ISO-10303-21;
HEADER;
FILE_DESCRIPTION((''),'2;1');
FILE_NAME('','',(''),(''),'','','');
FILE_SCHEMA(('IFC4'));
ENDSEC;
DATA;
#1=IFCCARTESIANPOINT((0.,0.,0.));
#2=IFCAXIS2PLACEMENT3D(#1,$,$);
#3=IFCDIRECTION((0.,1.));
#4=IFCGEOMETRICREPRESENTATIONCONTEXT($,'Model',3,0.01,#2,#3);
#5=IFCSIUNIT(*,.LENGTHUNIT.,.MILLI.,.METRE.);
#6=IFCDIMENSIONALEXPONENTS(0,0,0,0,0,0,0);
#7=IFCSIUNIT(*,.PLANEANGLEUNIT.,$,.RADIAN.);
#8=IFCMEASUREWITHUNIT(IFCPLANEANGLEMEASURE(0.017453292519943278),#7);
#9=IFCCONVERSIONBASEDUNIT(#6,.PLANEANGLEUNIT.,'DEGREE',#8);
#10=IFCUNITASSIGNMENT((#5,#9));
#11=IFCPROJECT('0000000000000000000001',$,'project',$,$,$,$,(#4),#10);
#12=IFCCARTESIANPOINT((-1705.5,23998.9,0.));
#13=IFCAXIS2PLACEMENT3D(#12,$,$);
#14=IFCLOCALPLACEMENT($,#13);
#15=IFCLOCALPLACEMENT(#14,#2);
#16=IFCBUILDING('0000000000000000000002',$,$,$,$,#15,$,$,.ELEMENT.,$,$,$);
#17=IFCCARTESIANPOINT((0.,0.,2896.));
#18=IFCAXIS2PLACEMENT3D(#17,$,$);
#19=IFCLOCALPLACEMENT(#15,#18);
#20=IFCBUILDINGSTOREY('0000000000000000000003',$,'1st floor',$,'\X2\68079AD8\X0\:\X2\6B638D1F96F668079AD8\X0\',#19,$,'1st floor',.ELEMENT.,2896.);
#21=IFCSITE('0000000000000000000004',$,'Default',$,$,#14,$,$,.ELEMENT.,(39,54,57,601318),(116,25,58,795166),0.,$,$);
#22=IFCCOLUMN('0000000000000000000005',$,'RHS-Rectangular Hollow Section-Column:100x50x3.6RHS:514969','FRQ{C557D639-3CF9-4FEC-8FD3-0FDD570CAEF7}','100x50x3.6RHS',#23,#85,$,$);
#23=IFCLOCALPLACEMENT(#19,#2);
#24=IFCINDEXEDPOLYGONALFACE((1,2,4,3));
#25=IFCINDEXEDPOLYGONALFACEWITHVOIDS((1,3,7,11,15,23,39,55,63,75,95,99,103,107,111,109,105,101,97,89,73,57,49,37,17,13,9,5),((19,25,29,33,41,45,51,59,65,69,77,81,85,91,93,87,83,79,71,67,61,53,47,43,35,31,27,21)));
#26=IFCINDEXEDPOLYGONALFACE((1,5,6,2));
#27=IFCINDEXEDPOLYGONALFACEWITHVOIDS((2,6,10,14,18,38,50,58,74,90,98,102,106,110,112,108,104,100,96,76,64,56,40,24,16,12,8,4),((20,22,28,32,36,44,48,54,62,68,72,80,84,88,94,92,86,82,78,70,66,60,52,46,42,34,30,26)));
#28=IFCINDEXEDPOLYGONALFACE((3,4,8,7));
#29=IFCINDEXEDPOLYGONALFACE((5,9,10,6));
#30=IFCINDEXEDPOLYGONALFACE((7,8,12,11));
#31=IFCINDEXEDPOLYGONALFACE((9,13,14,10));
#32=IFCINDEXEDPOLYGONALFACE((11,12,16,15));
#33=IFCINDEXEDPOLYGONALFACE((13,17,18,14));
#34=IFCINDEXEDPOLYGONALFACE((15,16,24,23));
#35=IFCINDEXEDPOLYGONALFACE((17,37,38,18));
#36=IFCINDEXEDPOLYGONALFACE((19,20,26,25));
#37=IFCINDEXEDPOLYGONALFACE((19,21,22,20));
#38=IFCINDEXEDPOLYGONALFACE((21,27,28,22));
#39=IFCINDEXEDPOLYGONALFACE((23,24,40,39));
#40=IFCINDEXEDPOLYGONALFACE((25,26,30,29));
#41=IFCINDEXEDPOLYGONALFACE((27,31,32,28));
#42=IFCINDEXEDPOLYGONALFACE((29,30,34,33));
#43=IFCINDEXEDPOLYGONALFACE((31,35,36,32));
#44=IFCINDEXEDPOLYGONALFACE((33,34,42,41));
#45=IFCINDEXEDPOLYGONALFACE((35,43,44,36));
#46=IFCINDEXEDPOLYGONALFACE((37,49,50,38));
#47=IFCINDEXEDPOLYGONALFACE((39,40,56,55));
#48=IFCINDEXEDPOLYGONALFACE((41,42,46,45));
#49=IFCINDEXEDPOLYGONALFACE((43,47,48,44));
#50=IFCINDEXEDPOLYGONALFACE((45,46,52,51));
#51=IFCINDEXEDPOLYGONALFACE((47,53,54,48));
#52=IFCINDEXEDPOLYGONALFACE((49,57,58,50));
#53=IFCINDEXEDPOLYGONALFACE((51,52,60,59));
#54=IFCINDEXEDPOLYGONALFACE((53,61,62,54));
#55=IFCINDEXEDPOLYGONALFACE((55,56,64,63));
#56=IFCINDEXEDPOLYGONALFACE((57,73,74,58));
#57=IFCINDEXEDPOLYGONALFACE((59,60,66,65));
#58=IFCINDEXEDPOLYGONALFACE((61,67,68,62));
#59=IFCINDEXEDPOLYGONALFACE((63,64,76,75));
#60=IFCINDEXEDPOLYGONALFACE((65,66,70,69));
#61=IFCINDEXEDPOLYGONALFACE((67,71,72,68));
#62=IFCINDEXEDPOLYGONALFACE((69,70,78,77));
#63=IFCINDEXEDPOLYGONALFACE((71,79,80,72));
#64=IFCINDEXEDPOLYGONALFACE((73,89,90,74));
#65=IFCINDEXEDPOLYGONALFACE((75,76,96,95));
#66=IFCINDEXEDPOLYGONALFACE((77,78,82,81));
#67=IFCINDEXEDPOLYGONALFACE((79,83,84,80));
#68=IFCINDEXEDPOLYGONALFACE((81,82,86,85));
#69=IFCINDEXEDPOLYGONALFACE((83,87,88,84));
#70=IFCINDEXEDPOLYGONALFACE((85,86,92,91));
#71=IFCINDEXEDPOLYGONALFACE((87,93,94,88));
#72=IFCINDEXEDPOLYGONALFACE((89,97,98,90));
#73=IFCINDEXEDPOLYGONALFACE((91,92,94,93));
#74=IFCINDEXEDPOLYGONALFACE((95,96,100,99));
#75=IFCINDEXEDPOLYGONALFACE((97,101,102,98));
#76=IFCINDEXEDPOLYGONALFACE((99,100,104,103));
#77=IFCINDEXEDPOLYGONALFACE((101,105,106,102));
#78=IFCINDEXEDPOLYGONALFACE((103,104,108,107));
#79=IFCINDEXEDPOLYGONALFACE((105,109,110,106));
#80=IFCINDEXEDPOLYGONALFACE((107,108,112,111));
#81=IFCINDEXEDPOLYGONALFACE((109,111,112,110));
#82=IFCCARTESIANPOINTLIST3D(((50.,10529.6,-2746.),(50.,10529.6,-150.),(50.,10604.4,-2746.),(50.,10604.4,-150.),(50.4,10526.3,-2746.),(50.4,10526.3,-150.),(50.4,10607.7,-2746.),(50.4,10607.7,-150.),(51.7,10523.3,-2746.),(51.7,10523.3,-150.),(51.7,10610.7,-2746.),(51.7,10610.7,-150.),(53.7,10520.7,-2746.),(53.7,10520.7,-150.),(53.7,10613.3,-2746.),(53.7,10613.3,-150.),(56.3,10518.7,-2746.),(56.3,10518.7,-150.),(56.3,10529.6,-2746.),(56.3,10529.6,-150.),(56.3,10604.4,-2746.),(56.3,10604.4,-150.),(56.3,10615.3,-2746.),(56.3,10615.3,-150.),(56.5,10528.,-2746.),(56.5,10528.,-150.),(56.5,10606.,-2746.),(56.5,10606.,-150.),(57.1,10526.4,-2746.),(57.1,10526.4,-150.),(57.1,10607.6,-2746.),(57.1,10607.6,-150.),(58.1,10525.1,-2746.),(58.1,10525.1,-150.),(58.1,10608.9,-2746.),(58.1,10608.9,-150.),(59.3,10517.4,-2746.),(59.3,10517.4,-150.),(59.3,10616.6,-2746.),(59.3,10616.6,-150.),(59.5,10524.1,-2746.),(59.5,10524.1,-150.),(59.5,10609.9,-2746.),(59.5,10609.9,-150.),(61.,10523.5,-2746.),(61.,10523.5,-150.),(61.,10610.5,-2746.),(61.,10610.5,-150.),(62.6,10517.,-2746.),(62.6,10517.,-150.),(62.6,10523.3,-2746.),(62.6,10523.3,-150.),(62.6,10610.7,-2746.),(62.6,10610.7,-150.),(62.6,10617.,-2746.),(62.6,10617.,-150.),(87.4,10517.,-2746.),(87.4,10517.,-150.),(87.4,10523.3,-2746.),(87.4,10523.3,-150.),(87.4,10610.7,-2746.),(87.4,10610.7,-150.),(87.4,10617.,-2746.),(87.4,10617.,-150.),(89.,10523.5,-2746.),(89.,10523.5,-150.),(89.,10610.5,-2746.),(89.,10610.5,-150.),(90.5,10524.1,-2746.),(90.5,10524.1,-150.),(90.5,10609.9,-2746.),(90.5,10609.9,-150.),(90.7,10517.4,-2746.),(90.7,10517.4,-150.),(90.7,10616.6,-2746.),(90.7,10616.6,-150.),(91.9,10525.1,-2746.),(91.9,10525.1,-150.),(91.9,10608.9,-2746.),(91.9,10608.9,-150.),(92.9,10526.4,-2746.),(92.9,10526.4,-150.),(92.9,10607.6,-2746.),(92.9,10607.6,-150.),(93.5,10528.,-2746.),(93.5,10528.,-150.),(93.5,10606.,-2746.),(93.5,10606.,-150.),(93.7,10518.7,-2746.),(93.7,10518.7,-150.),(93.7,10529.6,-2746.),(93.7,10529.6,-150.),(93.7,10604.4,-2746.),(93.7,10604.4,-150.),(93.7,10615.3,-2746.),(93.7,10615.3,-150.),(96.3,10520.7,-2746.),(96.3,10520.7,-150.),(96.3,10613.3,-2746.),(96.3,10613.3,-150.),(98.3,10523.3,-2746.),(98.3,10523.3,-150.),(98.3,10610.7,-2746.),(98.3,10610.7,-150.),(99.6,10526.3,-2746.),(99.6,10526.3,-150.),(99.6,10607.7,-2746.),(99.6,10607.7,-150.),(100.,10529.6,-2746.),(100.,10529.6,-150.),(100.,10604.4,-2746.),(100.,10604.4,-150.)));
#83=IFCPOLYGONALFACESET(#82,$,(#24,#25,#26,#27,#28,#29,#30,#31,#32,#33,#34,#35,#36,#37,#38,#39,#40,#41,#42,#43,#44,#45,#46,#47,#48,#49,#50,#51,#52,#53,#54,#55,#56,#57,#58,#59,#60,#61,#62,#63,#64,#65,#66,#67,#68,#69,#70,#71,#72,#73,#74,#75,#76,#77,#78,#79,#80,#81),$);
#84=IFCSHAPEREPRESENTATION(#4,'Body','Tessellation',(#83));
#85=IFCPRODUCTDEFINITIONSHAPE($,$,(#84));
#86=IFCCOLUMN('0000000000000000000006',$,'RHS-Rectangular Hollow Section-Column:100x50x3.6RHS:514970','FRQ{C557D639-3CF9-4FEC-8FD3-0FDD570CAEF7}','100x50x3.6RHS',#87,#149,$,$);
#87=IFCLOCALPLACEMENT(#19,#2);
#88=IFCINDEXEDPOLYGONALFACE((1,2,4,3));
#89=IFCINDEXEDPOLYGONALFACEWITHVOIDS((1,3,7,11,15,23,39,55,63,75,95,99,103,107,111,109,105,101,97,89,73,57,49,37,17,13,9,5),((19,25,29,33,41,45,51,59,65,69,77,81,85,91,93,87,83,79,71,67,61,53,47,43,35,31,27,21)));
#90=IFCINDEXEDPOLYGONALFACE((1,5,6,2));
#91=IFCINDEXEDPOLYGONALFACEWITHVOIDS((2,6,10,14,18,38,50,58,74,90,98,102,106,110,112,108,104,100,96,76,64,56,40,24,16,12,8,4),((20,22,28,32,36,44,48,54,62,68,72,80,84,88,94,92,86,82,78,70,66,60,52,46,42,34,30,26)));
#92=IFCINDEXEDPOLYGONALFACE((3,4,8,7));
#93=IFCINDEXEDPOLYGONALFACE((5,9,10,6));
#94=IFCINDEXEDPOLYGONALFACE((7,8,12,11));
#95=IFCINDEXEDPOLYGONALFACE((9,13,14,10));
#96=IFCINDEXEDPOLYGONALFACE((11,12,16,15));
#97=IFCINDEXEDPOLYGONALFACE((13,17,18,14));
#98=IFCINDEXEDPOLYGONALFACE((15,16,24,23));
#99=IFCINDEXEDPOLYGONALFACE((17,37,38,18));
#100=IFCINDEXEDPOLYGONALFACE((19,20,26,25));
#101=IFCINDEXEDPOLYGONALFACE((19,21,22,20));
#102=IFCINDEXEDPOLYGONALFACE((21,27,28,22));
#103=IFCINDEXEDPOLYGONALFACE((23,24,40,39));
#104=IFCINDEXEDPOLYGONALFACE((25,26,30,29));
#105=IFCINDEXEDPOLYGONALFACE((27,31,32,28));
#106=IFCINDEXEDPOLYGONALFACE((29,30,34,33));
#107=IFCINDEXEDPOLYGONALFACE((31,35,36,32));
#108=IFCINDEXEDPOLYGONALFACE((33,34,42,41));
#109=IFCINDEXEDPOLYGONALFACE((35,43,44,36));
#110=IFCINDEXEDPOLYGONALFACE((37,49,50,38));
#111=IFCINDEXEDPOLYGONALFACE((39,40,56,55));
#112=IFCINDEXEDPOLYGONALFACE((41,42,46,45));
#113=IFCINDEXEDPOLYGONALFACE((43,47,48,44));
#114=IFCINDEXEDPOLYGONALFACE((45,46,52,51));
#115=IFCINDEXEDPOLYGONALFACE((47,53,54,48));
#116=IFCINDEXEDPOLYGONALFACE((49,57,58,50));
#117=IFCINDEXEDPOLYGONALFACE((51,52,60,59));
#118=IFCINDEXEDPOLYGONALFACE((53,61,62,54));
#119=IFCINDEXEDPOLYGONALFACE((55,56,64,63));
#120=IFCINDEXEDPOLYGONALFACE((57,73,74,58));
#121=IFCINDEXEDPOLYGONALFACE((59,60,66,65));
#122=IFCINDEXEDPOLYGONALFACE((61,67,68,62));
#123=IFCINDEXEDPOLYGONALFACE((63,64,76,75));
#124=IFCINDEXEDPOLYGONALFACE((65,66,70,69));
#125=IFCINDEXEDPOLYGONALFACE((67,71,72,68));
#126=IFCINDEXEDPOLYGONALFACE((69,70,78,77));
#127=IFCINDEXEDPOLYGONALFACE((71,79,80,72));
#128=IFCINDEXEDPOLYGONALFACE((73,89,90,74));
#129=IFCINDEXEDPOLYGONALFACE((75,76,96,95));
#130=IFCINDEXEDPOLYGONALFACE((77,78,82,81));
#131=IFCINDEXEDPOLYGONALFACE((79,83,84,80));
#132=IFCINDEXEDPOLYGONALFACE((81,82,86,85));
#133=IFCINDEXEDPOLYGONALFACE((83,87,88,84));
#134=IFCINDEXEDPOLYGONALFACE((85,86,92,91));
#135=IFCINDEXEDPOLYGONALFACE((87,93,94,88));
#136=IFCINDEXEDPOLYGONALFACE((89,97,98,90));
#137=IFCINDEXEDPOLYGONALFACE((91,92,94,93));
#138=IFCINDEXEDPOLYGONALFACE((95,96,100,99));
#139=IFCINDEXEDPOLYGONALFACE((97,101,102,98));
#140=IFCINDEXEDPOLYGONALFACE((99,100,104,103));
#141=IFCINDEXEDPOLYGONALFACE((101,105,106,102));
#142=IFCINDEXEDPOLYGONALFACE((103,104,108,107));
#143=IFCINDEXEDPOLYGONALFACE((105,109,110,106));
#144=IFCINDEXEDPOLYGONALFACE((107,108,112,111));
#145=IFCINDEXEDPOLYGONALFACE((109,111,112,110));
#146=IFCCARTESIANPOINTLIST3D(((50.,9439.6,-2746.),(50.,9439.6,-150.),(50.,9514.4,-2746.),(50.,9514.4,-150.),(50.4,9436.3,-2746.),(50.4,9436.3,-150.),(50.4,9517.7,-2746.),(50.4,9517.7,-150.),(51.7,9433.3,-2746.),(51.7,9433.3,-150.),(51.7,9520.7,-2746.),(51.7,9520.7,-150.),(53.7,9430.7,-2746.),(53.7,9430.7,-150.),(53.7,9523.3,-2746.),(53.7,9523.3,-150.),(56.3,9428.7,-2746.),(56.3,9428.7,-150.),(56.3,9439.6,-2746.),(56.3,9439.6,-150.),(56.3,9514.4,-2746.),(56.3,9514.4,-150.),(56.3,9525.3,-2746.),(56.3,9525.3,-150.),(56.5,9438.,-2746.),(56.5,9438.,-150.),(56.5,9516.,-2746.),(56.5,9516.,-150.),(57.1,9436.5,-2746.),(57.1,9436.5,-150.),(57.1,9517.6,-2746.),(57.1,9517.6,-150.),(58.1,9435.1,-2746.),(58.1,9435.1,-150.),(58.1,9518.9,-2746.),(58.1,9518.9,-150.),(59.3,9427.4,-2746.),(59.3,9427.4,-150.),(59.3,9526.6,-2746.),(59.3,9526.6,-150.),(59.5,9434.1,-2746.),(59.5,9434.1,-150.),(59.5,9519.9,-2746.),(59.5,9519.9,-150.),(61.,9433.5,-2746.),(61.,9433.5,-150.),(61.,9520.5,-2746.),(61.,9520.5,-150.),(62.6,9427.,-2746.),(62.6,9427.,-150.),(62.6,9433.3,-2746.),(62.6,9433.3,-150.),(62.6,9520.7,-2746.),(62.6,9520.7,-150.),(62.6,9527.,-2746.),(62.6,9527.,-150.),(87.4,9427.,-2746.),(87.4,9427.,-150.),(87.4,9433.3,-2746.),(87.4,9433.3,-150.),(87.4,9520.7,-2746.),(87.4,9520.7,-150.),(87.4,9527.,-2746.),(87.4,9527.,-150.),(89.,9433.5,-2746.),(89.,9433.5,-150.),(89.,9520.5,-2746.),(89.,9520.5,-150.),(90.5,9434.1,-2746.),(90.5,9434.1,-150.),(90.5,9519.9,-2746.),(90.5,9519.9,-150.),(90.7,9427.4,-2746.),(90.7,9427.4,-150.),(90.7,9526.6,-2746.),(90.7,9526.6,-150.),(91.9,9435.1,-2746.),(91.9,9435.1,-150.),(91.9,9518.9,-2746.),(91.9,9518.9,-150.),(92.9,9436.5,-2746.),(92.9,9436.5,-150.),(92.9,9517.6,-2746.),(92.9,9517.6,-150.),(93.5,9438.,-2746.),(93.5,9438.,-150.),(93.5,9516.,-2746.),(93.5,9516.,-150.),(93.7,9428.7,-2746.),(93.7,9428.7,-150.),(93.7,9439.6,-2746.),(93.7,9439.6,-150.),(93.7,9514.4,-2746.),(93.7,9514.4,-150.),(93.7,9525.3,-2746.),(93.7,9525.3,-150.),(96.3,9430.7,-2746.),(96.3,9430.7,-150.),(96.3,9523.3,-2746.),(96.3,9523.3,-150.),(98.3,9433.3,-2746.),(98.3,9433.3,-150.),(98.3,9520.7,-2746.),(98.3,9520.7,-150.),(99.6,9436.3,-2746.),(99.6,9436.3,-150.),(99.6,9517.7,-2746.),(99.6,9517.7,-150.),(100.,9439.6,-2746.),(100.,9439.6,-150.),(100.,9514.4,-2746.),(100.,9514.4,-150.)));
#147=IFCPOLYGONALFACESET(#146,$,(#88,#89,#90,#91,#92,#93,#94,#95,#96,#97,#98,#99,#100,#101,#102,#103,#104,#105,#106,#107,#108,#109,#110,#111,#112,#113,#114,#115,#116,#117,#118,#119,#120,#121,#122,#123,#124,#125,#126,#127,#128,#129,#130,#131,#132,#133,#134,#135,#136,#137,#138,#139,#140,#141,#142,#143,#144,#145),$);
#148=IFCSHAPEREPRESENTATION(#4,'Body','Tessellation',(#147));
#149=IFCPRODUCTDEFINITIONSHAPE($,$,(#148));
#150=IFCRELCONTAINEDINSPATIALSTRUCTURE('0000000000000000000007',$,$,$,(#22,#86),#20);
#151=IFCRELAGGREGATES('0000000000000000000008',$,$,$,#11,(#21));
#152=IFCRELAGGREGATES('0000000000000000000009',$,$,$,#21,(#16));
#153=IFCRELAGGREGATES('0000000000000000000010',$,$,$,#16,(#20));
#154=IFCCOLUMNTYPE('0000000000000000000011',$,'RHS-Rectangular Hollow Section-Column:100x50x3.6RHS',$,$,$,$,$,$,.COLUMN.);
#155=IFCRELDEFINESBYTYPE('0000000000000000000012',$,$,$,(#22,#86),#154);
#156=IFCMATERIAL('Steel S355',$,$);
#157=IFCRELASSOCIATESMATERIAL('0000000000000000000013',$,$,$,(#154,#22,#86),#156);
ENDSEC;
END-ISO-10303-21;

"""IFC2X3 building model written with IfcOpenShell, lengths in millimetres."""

from ifc_helpers import new_model, entity, si_unit, converted_unit, point, direction, frame, frame_2d, origin, origin_2d, place, context, project, spatial, circle_curve, line_curve, trimmed, segment, composite_curve, hollow_rectangle, outline, extrude, clip, halfspace, material, type_object, element, save


model = new_model("IFC2X3")

# Units and contexts
model_context = context("Model", 3, precision=0.01, world=origin(), true_north=direction((0.0, 1.0)))
ifc_project = project(units=[si_unit("LENGTHUNIT", "METRE", prefix="MILLI"), converted_unit("PLANEANGLEUNIT", "DEGREE", entity("IfcPlaneAngleMeasure", 0.017453292519943278), si_unit("PLANEANGLEUNIT", "RADIAN"), dimensions=[0, 0, 0, 0, 0, 0, 0])], contexts=[model_context])

# Site, building, storey
site_placement = place(None, frame((-1705.5, 23998.9, 0.0)))
site = spatial("IfcSite", under=ifc_project, at=site_placement, Name="Default", CompositionType="ELEMENT", RefLatitude=(39, 54, 57, 601318), RefLongitude=(116, 25, 58, 795166), RefElevation=0.0)
building_placement = place(site_placement, origin())
building = spatial("IfcBuilding", under=site, at=building_placement, CompositionType="ELEMENT")
storey_placement = place(building_placement, frame((0.0, 0.0, 2896.0)))
storey = spatial("IfcBuildingStorey", under=building, at=storey_placement, Name="1st floor", ObjectType="标高:正负零标高", LongName="1st floor", CompositionType="ELEMENT", Elevation=2896.0)

# Shared definitions
ifc_material_1 = material(Name="Steel S355")

# Columns, openings
column_type_1 = type_object("IfcColumnType", Name="RHS-Rectangular Hollow Section-Column:100x50x3.6RHS", PredefinedType="COLUMN", material=ifc_material_1)
column_1_placement = place(storey_placement, frame((75.0, 10567.0, -19.1)))
column_1 = element("IfcColumn", 1, at=column_1_placement, inside=storey, type_object=column_type_1, material=ifc_material_1, Name="RHS-Rectangular Hollow Section-Column:100x50x3.6RHS:514969", Description="FRQ{C557D639-3CF9-4FEC-8FD3-0FDD570CAEF7}", ObjectType="100x50x3.6RHS", context=model_context, shape_type="Clipping", body=[
    clip(clip(extrude(hollow_rectangle(XDim=50.0, YDim=100.0, WallThickness=6.3, InnerFilletRadius=6.3, OuterFilletRadius=12.6, at=origin_2d()), origin(), (0.0, 0.0, -1.0), 2782.8), halfspace(frame((-75.0, -10567.0, -55.9), z_axis=(0.0, 0.0, -1.0), x_axis=(-1.0, 0.0, 0.0)), True)), halfspace(frame((-75.0, -10567.0, -2726.9), z_axis=(0.0, 0.0, 1.0), x_axis=(1.0, 0.0, 0.0)), True)),
])
opening_1_placement = place(column_1_placement, frame((0.0, -150.1, -130.9), z_axis=(0.0, 1.0, 0.0), x_axis=(-1.0, 0.0, 0.0)))
element("IfcOpeningElement", 2, at=opening_1_placement, cuts=column_1, ObjectType="Opening", context=model_context, shape_type="SweptSolid", body=[
    extrude(outline(composite_curve([segment(trimmed(circle_curve(frame_2d((43.0, 32.0), x_axis=(1.0, 0.0)), 32.0), [point((43.0, 0.0))], [point((75.0, 32.0))], True, "CARTESIAN"), True, "CONTINUOUS"), segment(trimmed(line_curve((75.0, 32.0), (0.0, 1.0), 86.0), [point((75.0, 32.0))], [point((75.0, 118.0))], True, "CARTESIAN"), True, "CONTINUOUS"), segment(trimmed(circle_curve(frame_2d((43.0, 118.0), x_axis=(1.0, 0.0)), 32.0), [point((75.0, 118.0))], [point((43.0, 150.0))], True, "CARTESIAN"), True, "CONTINUOUS"), segment(trimmed(line_curve((43.0, 150.0), (-1.0, 0.0), 86.0), [point((43.0, 150.0))], [point((-43.0, 150.0))], True, "CARTESIAN"), True, "CONTINUOUS"), segment(trimmed(circle_curve(frame_2d((-43.0, 118.0), x_axis=(1.0, 0.0)), 32.0), [point((-43.0, 150.0))], [point((-75.0, 118.0))], True, "CARTESIAN"), True, "CONTINUOUS"), segment(trimmed(line_curve((-75.0, 118.0), (0.0, -1.0), 86.0), [point((-75.0, 118.0))], [point((-75.0, 32.0))], True, "CARTESIAN"), True, "CONTINUOUS"), segment(trimmed(circle_curve(frame_2d((-43.0, 32.0), x_axis=(1.0, 0.0)), 32.0), [point((-75.0, 32.0))], [point((-43.0, 0.0))], True, "CARTESIAN"), True, "CONTINUOUS"), segment(trimmed(line_curve((-43.0, 0.0), (1.0, 0.0), 86.0), [point((-43.0, 0.0))], [point((43.0, 0.0))], True, "CARTESIAN"), True, "CONTINUOUS")], self_intersect="UNKNOWN")), origin(), (0.0, 0.0, 1.0), 300.2),
])
column_2_placement = place(storey_placement, frame((75.0, 9477.0, -19.1)))
column_2 = element("IfcColumn", 3, at=column_2_placement, inside=storey, type_object=column_type_1, material=ifc_material_1, Name="RHS-Rectangular Hollow Section-Column:100x50x3.6RHS:514970", Description="FRQ{C557D639-3CF9-4FEC-8FD3-0FDD570CAEF7}", ObjectType="100x50x3.6RHS", context=model_context, shape_type="Clipping", body=[
    clip(clip(extrude(hollow_rectangle(XDim=50.0, YDim=100.0, WallThickness=6.3, InnerFilletRadius=6.3, OuterFilletRadius=12.6, at=origin_2d()), origin(), (0.0, 0.0, -1.0), 2782.8), halfspace(frame((-75.0, -9477.0, -55.9), z_axis=(0.0, 0.0, -1.0), x_axis=(-1.0, 0.0, 0.0)), True)), halfspace(frame((-75.0, -9477.0, -2726.9), z_axis=(0.0, 0.0, 1.0), x_axis=(1.0, 0.0, 0.0)), True)),
])
opening_2_placement = place(column_2_placement, frame((0.0, -150.1, -130.9), z_axis=(0.0, 1.0, 0.0), x_axis=(-1.0, 0.0, 0.0)))
element("IfcOpeningElement", 4, at=opening_2_placement, cuts=column_2, ObjectType="Opening", context=model_context, shape_type="SweptSolid", body=[
    extrude(outline(composite_curve([segment(trimmed(circle_curve(frame_2d((43.0, 32.0), x_axis=(1.0, 0.0)), 32.0), [point((43.0, 0.0))], [point((75.0, 32.0))], True, "CARTESIAN"), True, "CONTINUOUS"), segment(trimmed(line_curve((75.0, 32.0), (0.0, 1.0), 86.0), [point((75.0, 32.0))], [point((75.0, 118.0))], True, "CARTESIAN"), True, "CONTINUOUS"), segment(trimmed(circle_curve(frame_2d((43.0, 118.0), x_axis=(1.0, 0.0)), 32.0), [point((75.0, 118.0))], [point((43.0, 150.0))], True, "CARTESIAN"), True, "CONTINUOUS"), segment(trimmed(line_curve((43.0, 150.0), (-1.0, 0.0), 86.0), [point((43.0, 150.0))], [point((-43.0, 150.0))], True, "CARTESIAN"), True, "CONTINUOUS"), segment(trimmed(circle_curve(frame_2d((-43.0, 118.0), x_axis=(1.0, 0.0)), 32.0), [point((-43.0, 150.0))], [point((-75.0, 118.0))], True, "CARTESIAN"), True, "CONTINUOUS"), segment(trimmed(line_curve((-75.0, 118.0), (0.0, -1.0), 86.0), [point((-75.0, 118.0))], [point((-75.0, 32.0))], True, "CARTESIAN"), True, "CONTINUOUS"), segment(trimmed(circle_curve(frame_2d((-43.0, 32.0), x_axis=(1.0, 0.0)), 32.0), [point((-75.0, 32.0))], [point((-43.0, 0.0))], True, "CARTESIAN"), True, "CONTINUOUS"), segment(trimmed(line_curve((-43.0, 0.0), (1.0, 0.0), 86.0), [point((-43.0, 0.0))], [point((43.0, 0.0))], True, "CARTESIAN"), True, "CONTINUOUS")], self_intersect="UNKNOWN")), origin(), (0.0, 0.0, 1.0), 300.2),
])

save(model, "model.ifc")
